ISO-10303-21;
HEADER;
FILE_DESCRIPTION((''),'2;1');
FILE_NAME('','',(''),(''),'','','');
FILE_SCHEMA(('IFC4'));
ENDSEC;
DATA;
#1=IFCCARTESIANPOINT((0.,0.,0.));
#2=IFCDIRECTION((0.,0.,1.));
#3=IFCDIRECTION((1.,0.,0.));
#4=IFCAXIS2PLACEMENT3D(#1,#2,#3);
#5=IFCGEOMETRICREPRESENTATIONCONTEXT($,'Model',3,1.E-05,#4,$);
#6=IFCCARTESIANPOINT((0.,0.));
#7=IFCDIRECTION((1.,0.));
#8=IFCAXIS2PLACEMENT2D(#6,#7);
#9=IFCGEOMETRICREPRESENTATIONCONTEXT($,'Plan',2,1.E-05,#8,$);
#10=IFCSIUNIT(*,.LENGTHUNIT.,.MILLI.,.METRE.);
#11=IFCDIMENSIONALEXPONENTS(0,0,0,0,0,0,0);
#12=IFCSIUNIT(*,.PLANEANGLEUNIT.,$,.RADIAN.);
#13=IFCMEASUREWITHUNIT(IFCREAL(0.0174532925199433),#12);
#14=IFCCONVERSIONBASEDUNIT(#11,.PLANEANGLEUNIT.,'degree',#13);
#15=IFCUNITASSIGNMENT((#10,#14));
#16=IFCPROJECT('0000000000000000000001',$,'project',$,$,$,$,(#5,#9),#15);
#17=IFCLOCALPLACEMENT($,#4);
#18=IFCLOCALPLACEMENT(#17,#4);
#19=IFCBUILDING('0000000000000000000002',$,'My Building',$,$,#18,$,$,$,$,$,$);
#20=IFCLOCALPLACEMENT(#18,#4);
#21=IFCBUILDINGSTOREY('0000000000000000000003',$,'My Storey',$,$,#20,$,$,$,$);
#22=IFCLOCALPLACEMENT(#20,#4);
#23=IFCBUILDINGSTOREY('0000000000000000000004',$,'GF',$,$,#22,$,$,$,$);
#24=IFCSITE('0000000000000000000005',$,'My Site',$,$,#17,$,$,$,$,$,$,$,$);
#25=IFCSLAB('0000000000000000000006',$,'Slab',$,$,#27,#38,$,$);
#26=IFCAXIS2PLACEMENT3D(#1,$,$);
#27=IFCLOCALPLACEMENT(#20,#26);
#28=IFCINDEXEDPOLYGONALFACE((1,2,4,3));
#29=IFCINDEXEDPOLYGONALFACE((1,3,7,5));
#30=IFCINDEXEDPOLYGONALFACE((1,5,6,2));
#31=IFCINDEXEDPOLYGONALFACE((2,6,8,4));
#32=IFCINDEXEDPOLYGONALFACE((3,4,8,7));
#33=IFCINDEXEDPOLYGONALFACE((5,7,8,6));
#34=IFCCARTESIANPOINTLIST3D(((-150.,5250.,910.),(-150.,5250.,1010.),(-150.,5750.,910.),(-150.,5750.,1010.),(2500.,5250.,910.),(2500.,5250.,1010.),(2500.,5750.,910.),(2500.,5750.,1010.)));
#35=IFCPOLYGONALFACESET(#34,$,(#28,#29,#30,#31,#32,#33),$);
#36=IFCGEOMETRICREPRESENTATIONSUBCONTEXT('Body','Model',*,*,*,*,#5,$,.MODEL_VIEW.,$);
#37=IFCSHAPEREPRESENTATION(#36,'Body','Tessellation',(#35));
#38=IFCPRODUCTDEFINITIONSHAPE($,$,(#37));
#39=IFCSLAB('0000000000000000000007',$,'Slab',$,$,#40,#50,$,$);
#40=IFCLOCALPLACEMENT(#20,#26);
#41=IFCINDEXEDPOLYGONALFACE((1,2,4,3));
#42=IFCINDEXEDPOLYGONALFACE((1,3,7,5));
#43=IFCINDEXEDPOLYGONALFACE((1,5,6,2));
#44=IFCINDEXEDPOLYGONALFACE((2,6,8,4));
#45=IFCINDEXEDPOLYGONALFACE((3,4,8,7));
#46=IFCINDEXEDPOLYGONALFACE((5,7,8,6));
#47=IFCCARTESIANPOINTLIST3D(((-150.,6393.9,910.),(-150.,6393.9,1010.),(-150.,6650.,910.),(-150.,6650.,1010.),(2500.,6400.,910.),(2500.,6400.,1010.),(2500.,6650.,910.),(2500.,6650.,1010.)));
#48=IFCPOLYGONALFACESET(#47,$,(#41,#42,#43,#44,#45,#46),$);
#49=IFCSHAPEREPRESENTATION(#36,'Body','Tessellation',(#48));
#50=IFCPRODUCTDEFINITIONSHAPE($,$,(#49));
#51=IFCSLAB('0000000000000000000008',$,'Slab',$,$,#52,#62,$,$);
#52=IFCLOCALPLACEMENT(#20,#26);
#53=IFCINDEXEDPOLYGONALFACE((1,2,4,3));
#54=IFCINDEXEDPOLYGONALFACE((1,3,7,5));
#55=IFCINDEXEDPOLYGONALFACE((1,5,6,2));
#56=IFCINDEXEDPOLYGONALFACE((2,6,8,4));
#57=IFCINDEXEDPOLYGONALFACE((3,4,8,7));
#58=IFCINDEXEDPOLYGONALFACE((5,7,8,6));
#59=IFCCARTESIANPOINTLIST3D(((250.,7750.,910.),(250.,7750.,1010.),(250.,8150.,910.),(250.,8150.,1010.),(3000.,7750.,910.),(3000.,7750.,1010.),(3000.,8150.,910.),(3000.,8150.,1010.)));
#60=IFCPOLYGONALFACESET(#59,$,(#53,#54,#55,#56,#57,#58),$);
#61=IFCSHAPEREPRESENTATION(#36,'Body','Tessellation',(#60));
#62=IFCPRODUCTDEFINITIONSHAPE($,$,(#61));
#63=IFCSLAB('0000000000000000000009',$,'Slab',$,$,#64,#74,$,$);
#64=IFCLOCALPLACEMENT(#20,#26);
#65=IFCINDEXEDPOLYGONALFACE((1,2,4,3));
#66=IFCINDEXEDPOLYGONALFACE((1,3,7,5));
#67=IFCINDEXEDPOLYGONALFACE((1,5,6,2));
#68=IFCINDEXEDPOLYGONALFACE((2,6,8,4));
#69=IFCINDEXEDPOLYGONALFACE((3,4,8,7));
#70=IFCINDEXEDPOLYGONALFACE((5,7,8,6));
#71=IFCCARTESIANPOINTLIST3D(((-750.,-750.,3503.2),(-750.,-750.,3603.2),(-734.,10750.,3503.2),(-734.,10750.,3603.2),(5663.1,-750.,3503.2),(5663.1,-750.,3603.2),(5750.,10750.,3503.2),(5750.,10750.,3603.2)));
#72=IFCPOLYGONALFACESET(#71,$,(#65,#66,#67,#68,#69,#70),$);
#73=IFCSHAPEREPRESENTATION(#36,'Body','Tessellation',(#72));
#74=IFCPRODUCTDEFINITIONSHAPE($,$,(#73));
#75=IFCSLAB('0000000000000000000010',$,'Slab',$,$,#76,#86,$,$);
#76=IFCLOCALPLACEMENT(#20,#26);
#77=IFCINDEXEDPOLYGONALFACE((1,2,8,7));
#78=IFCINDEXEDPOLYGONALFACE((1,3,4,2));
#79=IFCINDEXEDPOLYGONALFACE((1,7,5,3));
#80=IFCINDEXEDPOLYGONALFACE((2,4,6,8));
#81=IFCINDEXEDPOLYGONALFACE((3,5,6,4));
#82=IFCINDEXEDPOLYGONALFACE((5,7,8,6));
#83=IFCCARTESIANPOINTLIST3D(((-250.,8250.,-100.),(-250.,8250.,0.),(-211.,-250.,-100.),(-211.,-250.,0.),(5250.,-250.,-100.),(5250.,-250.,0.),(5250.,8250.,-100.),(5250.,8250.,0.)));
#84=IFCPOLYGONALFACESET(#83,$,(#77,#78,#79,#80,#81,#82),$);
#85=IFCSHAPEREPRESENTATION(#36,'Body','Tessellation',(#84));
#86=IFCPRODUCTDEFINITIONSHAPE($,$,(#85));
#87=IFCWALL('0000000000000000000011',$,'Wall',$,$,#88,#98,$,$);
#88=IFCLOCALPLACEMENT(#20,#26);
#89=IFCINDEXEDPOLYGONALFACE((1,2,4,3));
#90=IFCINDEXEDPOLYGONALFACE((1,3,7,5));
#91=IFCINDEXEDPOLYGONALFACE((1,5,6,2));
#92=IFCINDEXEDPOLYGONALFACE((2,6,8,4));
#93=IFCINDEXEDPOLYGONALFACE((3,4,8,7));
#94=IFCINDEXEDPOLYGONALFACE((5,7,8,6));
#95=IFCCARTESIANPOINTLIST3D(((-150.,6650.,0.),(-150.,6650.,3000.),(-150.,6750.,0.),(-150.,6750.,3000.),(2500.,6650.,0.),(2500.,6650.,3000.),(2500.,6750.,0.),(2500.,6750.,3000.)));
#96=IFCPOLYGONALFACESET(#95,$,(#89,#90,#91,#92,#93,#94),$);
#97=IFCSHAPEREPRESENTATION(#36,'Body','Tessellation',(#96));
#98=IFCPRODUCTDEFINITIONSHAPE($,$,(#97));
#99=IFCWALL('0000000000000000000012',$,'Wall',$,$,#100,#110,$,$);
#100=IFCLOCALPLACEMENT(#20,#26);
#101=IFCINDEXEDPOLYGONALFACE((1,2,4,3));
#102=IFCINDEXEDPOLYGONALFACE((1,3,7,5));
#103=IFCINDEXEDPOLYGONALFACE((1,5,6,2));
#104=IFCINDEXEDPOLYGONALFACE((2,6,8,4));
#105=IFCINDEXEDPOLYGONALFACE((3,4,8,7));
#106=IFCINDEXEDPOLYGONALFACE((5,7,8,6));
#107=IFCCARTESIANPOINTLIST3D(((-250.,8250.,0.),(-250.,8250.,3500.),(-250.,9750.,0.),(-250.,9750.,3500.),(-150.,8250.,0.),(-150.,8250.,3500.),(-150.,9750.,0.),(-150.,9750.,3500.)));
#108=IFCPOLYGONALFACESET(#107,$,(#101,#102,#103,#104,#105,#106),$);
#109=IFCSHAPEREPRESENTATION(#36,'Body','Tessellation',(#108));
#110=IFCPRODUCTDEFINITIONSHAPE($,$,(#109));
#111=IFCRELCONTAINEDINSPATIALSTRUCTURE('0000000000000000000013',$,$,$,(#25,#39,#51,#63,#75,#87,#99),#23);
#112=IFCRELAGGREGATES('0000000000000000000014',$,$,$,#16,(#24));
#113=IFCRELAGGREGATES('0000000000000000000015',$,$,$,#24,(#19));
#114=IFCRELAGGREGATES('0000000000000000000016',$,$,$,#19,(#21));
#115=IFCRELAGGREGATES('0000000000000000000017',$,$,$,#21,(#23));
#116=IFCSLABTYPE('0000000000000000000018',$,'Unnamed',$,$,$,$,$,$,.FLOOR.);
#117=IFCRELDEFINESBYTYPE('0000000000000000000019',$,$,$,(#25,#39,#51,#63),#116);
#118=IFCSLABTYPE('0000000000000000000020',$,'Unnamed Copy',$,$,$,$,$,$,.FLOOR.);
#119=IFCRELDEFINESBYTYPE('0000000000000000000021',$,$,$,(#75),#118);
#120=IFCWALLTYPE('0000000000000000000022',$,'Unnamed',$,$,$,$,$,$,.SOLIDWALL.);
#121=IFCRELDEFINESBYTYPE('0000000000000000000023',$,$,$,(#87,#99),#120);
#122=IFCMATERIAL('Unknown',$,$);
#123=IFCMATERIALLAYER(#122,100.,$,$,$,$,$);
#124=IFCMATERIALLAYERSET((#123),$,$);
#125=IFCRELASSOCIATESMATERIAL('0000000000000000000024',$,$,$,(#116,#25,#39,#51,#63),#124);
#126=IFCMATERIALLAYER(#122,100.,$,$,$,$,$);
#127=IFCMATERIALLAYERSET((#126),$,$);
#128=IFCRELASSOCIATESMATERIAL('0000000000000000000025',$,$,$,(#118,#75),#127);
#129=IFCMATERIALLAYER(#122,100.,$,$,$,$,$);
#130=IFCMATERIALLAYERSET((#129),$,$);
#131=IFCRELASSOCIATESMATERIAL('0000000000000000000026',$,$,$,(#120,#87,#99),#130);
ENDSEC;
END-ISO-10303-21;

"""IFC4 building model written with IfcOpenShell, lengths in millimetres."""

from ifc_helpers import new_model, entity, si_unit, converted_unit, frame, origin_with_axes, origin_2d_with_axis, place, context, subcontext, project, spatial, line, indexed_curve, outline, extrude, material, layer, layer_set, layer_usage, type_object, element, save


model = new_model("IFC4")

# Units and contexts
model_context = context("Model", 3, precision=1e-05, world=origin_with_axes())
plan_context = context("Plan", 2, precision=1e-05, world=origin_2d_with_axis())
body_context_1 = subcontext(model_context, "Body", "Model", "MODEL_VIEW")
ifc_project = project(units=[si_unit("LENGTHUNIT", "METRE", prefix="MILLI"), converted_unit("PLANEANGLEUNIT", "degree", entity("IfcReal", 0.0174532925199433), si_unit("PLANEANGLEUNIT", "RADIAN"), dimensions=[0, 0, 0, 0, 0, 0, 0])], contexts=[model_context, plan_context])

# Site, building, storeys
site_placement = place(None, origin_with_axes())
site = spatial("IfcSite", under=ifc_project, at=site_placement, Name="My Site")
building_placement = place(site_placement, origin_with_axes())
building = spatial("IfcBuilding", under=site, at=building_placement, Name="My Building")
storey_1_placement = place(building_placement, origin_with_axes())
storey_1 = spatial("IfcBuildingStorey", under=building, at=storey_1_placement, Name="My Storey")
storey_2_placement = place(storey_1_placement, origin_with_axes())
storey_2 = spatial("IfcBuildingStorey", under=storey_1, at=storey_2_placement, Name="GF")

# Slabs
ifc_material = material(Name="Unknown")
ifc_layer_1 = layer(ifc_material, 100.0)
ifc_layer_set_1 = layer_set([ifc_layer_1])
ifc_layer_usage_1 = layer_usage(ifc_layer_set_1, "AXIS3", "POSITIVE", -100.0)
slab_type_1 = type_object("IfcSlabType", Name="Unnamed", PredefinedType="FLOOR", material=ifc_layer_set_1)
slab_1_placement = place(storey_2_placement, frame((-150.0, 5250.0, 1010.0), z_axis=(0.0, 0.0, 1.0), x_axis=(1.0, 0.0, 0.0)))
element("IfcSlab", 1, at=slab_1_placement, inside=storey_2, type_object=slab_type_1, material=ifc_layer_usage_1, Name="Slab", context=body_context_1, shape_type="SweptSolid", body=[
    extrude(outline(indexed_curve([(0.0, 0.0), (2650.0, 0.0), (2650.0, 500.0), (0.0, 500.0), (0.0, 0.0)])), frame((0.0, 0.0, -100.0), z_axis=(0.0, 0.0, 1.0), x_axis=(1.0, 0.0, 0.0)), (0.0, 0.0, 1.0), 100.0),
])
ifc_layer_usage_2 = layer_usage(ifc_layer_set_1, "AXIS3", "POSITIVE", -100.0)
slab_2_placement = place(storey_2_placement, frame((-150.0, 6650.0, 1010.0), z_axis=(0.0, 0.0, 1.0), x_axis=(1.0, 0.0, 0.0)))
element("IfcSlab", 2, at=slab_2_placement, inside=storey_2, type_object=slab_type_1, material=ifc_layer_usage_2, Name="Slab", context=body_context_1, shape_type="SweptSolid", body=[
    extrude(outline(indexed_curve([(0.0, 0.0), (2650.0, 0.0), (2650.0, -250.0), (0.0, -256.1), (0.0, 0.0)])), frame((0.0, 0.0, -100.0), z_axis=(0.0, 0.0, 1.0), x_axis=(1.0, 0.0, 0.0)), (0.0, 0.0, 1.0), 100.0),
])
ifc_layer_usage_3 = layer_usage(ifc_layer_set_1, "AXIS3", "POSITIVE", -100.0)
slab_3_placement = place(storey_2_placement, frame((250.0, 7750.0, 1010.0), z_axis=(0.0, 0.0, 1.0), x_axis=(1.0, 0.0, 0.0)))
element("IfcSlab", 3, at=slab_3_placement, inside=storey_2, type_object=slab_type_1, material=ifc_layer_usage_3, Name="Slab", context=body_context_1, shape_type="SweptSolid", body=[
    extrude(outline(indexed_curve([(0.0, 0.0), (2750.0, 0.0), (2750.0, 400.0), (0.0, 400.0), (0.0, 0.0)])), frame((0.0, 0.0, -100.0), z_axis=(0.0, 0.0, 1.0), x_axis=(1.0, 0.0, 0.0)), (0.0, 0.0, 1.0), 100.0),
])
ifc_layer_usage_4 = layer_usage(ifc_layer_set_1, "AXIS3", "POSITIVE", -100.0)
slab_4_placement = place(storey_2_placement, frame((-734.0, 10750.0, 3603.2), z_axis=(0.0, 0.0, 1.0), x_axis=(1.0, 0.0, 0.0)))
element("IfcSlab", 4, at=slab_4_placement, inside=storey_2, type_object=slab_type_1, material=ifc_layer_usage_4, Name="Slab", context=body_context_1, shape_type="SweptSolid", body=[
    extrude(outline(indexed_curve([(0.0, 0.0), (6484.0, 0.0), (6397.0, -11500.0), (-16.0, -11500.0), (0.0, 0.0)])), frame((0.0, 0.0, -100.0), z_axis=(0.0, 0.0, 1.0), x_axis=(1.0, 0.0, 0.0)), (0.0, 0.0, 1.0), 100.0),
])
ifc_layer_2 = layer(ifc_material, 100.0)
ifc_layer_set_2 = layer_set([ifc_layer_2])
ifc_layer_usage_5 = layer_usage(ifc_layer_set_2, "AXIS3", "POSITIVE", -100.0)
slab_type_2 = type_object("IfcSlabType", Name="Unnamed Copy", PredefinedType="FLOOR", material=ifc_layer_set_2)
slab_5_placement = place(storey_2_placement, frame((-250.0, 8250.0, 0.0), z_axis=(0.0, 0.0, 1.0), x_axis=(1.0, 0.0, 0.0)))
element("IfcSlab", 5, at=slab_5_placement, inside=storey_2, type_object=slab_type_2, material=ifc_layer_usage_5, Name="Slab", context=body_context_1, shape_type="SweptSolid", body=[
    extrude(outline(indexed_curve([(0.0, 0.0), (5500.0, 0.0), (5500.0, -8500.0), (39.0, -8500.0), (0.0, 0.0)])), frame((0.0, 0.0, -100.0), z_axis=(0.0, 0.0, 1.0), x_axis=(1.0, 0.0, 0.0)), (0.0, 0.0, 1.0), 100.0),
])

# Walls
ifc_layer_3 = layer(ifc_material, 100.0)
ifc_layer_set_3 = layer_set([ifc_layer_3])
ifc_layer_usage_6 = layer_usage(ifc_layer_set_3, "AXIS2", "POSITIVE", 0.0)
wall_type_1 = type_object("IfcWallType", Name="Unnamed", PredefinedType="SOLIDWALL", material=ifc_layer_set_3)
wall_1_placement = place(storey_2_placement, frame((-150.0, 6650.0, 0.0), z_axis=(0.0, 0.0, 1.0), x_axis=(1.0, 0.0, 0.0)))
element("IfcWall", 6, at=wall_1_placement, inside=storey_2, type_object=wall_type_1, material=ifc_layer_usage_6, Name="Wall", context=body_context_1, shape_type="SweptSolid", body=[
    extrude(outline(indexed_curve([(0.0, 0.0), (0.0, 100.0), (2650.0, 100.0), (2650.0, 0.0)], segments=[line(1, 2, 3, 4, 1)])), origin_with_axes(), (0.0, 0.0, 1.0), 3000.0),
])
ifc_layer_usage_7 = layer_usage(ifc_layer_set_3, "AXIS2", "POSITIVE", 0.0)
wall_2_placement = place(storey_2_placement, frame((-250.0, 9750.0, 0.0), z_axis=(0.0, 0.0, 1.0), x_axis=(0.0, -1.0, 0.0)))
element("IfcWall", 7, at=wall_2_placement, inside=storey_2, type_object=wall_type_1, material=ifc_layer_usage_7, Name="Wall", context=body_context_1, shape_type="SweptSolid", body=[
    extrude(outline(indexed_curve([(0.0, 0.0), (0.0, 100.0), (1500.0, 100.0), (1500.0, 0.0)], segments=[line(1, 2, 3, 4, 1)])), origin_with_axes(), (0.0, 0.0, 1.0), 3500.0),
])

save(model, "model.ifc")
